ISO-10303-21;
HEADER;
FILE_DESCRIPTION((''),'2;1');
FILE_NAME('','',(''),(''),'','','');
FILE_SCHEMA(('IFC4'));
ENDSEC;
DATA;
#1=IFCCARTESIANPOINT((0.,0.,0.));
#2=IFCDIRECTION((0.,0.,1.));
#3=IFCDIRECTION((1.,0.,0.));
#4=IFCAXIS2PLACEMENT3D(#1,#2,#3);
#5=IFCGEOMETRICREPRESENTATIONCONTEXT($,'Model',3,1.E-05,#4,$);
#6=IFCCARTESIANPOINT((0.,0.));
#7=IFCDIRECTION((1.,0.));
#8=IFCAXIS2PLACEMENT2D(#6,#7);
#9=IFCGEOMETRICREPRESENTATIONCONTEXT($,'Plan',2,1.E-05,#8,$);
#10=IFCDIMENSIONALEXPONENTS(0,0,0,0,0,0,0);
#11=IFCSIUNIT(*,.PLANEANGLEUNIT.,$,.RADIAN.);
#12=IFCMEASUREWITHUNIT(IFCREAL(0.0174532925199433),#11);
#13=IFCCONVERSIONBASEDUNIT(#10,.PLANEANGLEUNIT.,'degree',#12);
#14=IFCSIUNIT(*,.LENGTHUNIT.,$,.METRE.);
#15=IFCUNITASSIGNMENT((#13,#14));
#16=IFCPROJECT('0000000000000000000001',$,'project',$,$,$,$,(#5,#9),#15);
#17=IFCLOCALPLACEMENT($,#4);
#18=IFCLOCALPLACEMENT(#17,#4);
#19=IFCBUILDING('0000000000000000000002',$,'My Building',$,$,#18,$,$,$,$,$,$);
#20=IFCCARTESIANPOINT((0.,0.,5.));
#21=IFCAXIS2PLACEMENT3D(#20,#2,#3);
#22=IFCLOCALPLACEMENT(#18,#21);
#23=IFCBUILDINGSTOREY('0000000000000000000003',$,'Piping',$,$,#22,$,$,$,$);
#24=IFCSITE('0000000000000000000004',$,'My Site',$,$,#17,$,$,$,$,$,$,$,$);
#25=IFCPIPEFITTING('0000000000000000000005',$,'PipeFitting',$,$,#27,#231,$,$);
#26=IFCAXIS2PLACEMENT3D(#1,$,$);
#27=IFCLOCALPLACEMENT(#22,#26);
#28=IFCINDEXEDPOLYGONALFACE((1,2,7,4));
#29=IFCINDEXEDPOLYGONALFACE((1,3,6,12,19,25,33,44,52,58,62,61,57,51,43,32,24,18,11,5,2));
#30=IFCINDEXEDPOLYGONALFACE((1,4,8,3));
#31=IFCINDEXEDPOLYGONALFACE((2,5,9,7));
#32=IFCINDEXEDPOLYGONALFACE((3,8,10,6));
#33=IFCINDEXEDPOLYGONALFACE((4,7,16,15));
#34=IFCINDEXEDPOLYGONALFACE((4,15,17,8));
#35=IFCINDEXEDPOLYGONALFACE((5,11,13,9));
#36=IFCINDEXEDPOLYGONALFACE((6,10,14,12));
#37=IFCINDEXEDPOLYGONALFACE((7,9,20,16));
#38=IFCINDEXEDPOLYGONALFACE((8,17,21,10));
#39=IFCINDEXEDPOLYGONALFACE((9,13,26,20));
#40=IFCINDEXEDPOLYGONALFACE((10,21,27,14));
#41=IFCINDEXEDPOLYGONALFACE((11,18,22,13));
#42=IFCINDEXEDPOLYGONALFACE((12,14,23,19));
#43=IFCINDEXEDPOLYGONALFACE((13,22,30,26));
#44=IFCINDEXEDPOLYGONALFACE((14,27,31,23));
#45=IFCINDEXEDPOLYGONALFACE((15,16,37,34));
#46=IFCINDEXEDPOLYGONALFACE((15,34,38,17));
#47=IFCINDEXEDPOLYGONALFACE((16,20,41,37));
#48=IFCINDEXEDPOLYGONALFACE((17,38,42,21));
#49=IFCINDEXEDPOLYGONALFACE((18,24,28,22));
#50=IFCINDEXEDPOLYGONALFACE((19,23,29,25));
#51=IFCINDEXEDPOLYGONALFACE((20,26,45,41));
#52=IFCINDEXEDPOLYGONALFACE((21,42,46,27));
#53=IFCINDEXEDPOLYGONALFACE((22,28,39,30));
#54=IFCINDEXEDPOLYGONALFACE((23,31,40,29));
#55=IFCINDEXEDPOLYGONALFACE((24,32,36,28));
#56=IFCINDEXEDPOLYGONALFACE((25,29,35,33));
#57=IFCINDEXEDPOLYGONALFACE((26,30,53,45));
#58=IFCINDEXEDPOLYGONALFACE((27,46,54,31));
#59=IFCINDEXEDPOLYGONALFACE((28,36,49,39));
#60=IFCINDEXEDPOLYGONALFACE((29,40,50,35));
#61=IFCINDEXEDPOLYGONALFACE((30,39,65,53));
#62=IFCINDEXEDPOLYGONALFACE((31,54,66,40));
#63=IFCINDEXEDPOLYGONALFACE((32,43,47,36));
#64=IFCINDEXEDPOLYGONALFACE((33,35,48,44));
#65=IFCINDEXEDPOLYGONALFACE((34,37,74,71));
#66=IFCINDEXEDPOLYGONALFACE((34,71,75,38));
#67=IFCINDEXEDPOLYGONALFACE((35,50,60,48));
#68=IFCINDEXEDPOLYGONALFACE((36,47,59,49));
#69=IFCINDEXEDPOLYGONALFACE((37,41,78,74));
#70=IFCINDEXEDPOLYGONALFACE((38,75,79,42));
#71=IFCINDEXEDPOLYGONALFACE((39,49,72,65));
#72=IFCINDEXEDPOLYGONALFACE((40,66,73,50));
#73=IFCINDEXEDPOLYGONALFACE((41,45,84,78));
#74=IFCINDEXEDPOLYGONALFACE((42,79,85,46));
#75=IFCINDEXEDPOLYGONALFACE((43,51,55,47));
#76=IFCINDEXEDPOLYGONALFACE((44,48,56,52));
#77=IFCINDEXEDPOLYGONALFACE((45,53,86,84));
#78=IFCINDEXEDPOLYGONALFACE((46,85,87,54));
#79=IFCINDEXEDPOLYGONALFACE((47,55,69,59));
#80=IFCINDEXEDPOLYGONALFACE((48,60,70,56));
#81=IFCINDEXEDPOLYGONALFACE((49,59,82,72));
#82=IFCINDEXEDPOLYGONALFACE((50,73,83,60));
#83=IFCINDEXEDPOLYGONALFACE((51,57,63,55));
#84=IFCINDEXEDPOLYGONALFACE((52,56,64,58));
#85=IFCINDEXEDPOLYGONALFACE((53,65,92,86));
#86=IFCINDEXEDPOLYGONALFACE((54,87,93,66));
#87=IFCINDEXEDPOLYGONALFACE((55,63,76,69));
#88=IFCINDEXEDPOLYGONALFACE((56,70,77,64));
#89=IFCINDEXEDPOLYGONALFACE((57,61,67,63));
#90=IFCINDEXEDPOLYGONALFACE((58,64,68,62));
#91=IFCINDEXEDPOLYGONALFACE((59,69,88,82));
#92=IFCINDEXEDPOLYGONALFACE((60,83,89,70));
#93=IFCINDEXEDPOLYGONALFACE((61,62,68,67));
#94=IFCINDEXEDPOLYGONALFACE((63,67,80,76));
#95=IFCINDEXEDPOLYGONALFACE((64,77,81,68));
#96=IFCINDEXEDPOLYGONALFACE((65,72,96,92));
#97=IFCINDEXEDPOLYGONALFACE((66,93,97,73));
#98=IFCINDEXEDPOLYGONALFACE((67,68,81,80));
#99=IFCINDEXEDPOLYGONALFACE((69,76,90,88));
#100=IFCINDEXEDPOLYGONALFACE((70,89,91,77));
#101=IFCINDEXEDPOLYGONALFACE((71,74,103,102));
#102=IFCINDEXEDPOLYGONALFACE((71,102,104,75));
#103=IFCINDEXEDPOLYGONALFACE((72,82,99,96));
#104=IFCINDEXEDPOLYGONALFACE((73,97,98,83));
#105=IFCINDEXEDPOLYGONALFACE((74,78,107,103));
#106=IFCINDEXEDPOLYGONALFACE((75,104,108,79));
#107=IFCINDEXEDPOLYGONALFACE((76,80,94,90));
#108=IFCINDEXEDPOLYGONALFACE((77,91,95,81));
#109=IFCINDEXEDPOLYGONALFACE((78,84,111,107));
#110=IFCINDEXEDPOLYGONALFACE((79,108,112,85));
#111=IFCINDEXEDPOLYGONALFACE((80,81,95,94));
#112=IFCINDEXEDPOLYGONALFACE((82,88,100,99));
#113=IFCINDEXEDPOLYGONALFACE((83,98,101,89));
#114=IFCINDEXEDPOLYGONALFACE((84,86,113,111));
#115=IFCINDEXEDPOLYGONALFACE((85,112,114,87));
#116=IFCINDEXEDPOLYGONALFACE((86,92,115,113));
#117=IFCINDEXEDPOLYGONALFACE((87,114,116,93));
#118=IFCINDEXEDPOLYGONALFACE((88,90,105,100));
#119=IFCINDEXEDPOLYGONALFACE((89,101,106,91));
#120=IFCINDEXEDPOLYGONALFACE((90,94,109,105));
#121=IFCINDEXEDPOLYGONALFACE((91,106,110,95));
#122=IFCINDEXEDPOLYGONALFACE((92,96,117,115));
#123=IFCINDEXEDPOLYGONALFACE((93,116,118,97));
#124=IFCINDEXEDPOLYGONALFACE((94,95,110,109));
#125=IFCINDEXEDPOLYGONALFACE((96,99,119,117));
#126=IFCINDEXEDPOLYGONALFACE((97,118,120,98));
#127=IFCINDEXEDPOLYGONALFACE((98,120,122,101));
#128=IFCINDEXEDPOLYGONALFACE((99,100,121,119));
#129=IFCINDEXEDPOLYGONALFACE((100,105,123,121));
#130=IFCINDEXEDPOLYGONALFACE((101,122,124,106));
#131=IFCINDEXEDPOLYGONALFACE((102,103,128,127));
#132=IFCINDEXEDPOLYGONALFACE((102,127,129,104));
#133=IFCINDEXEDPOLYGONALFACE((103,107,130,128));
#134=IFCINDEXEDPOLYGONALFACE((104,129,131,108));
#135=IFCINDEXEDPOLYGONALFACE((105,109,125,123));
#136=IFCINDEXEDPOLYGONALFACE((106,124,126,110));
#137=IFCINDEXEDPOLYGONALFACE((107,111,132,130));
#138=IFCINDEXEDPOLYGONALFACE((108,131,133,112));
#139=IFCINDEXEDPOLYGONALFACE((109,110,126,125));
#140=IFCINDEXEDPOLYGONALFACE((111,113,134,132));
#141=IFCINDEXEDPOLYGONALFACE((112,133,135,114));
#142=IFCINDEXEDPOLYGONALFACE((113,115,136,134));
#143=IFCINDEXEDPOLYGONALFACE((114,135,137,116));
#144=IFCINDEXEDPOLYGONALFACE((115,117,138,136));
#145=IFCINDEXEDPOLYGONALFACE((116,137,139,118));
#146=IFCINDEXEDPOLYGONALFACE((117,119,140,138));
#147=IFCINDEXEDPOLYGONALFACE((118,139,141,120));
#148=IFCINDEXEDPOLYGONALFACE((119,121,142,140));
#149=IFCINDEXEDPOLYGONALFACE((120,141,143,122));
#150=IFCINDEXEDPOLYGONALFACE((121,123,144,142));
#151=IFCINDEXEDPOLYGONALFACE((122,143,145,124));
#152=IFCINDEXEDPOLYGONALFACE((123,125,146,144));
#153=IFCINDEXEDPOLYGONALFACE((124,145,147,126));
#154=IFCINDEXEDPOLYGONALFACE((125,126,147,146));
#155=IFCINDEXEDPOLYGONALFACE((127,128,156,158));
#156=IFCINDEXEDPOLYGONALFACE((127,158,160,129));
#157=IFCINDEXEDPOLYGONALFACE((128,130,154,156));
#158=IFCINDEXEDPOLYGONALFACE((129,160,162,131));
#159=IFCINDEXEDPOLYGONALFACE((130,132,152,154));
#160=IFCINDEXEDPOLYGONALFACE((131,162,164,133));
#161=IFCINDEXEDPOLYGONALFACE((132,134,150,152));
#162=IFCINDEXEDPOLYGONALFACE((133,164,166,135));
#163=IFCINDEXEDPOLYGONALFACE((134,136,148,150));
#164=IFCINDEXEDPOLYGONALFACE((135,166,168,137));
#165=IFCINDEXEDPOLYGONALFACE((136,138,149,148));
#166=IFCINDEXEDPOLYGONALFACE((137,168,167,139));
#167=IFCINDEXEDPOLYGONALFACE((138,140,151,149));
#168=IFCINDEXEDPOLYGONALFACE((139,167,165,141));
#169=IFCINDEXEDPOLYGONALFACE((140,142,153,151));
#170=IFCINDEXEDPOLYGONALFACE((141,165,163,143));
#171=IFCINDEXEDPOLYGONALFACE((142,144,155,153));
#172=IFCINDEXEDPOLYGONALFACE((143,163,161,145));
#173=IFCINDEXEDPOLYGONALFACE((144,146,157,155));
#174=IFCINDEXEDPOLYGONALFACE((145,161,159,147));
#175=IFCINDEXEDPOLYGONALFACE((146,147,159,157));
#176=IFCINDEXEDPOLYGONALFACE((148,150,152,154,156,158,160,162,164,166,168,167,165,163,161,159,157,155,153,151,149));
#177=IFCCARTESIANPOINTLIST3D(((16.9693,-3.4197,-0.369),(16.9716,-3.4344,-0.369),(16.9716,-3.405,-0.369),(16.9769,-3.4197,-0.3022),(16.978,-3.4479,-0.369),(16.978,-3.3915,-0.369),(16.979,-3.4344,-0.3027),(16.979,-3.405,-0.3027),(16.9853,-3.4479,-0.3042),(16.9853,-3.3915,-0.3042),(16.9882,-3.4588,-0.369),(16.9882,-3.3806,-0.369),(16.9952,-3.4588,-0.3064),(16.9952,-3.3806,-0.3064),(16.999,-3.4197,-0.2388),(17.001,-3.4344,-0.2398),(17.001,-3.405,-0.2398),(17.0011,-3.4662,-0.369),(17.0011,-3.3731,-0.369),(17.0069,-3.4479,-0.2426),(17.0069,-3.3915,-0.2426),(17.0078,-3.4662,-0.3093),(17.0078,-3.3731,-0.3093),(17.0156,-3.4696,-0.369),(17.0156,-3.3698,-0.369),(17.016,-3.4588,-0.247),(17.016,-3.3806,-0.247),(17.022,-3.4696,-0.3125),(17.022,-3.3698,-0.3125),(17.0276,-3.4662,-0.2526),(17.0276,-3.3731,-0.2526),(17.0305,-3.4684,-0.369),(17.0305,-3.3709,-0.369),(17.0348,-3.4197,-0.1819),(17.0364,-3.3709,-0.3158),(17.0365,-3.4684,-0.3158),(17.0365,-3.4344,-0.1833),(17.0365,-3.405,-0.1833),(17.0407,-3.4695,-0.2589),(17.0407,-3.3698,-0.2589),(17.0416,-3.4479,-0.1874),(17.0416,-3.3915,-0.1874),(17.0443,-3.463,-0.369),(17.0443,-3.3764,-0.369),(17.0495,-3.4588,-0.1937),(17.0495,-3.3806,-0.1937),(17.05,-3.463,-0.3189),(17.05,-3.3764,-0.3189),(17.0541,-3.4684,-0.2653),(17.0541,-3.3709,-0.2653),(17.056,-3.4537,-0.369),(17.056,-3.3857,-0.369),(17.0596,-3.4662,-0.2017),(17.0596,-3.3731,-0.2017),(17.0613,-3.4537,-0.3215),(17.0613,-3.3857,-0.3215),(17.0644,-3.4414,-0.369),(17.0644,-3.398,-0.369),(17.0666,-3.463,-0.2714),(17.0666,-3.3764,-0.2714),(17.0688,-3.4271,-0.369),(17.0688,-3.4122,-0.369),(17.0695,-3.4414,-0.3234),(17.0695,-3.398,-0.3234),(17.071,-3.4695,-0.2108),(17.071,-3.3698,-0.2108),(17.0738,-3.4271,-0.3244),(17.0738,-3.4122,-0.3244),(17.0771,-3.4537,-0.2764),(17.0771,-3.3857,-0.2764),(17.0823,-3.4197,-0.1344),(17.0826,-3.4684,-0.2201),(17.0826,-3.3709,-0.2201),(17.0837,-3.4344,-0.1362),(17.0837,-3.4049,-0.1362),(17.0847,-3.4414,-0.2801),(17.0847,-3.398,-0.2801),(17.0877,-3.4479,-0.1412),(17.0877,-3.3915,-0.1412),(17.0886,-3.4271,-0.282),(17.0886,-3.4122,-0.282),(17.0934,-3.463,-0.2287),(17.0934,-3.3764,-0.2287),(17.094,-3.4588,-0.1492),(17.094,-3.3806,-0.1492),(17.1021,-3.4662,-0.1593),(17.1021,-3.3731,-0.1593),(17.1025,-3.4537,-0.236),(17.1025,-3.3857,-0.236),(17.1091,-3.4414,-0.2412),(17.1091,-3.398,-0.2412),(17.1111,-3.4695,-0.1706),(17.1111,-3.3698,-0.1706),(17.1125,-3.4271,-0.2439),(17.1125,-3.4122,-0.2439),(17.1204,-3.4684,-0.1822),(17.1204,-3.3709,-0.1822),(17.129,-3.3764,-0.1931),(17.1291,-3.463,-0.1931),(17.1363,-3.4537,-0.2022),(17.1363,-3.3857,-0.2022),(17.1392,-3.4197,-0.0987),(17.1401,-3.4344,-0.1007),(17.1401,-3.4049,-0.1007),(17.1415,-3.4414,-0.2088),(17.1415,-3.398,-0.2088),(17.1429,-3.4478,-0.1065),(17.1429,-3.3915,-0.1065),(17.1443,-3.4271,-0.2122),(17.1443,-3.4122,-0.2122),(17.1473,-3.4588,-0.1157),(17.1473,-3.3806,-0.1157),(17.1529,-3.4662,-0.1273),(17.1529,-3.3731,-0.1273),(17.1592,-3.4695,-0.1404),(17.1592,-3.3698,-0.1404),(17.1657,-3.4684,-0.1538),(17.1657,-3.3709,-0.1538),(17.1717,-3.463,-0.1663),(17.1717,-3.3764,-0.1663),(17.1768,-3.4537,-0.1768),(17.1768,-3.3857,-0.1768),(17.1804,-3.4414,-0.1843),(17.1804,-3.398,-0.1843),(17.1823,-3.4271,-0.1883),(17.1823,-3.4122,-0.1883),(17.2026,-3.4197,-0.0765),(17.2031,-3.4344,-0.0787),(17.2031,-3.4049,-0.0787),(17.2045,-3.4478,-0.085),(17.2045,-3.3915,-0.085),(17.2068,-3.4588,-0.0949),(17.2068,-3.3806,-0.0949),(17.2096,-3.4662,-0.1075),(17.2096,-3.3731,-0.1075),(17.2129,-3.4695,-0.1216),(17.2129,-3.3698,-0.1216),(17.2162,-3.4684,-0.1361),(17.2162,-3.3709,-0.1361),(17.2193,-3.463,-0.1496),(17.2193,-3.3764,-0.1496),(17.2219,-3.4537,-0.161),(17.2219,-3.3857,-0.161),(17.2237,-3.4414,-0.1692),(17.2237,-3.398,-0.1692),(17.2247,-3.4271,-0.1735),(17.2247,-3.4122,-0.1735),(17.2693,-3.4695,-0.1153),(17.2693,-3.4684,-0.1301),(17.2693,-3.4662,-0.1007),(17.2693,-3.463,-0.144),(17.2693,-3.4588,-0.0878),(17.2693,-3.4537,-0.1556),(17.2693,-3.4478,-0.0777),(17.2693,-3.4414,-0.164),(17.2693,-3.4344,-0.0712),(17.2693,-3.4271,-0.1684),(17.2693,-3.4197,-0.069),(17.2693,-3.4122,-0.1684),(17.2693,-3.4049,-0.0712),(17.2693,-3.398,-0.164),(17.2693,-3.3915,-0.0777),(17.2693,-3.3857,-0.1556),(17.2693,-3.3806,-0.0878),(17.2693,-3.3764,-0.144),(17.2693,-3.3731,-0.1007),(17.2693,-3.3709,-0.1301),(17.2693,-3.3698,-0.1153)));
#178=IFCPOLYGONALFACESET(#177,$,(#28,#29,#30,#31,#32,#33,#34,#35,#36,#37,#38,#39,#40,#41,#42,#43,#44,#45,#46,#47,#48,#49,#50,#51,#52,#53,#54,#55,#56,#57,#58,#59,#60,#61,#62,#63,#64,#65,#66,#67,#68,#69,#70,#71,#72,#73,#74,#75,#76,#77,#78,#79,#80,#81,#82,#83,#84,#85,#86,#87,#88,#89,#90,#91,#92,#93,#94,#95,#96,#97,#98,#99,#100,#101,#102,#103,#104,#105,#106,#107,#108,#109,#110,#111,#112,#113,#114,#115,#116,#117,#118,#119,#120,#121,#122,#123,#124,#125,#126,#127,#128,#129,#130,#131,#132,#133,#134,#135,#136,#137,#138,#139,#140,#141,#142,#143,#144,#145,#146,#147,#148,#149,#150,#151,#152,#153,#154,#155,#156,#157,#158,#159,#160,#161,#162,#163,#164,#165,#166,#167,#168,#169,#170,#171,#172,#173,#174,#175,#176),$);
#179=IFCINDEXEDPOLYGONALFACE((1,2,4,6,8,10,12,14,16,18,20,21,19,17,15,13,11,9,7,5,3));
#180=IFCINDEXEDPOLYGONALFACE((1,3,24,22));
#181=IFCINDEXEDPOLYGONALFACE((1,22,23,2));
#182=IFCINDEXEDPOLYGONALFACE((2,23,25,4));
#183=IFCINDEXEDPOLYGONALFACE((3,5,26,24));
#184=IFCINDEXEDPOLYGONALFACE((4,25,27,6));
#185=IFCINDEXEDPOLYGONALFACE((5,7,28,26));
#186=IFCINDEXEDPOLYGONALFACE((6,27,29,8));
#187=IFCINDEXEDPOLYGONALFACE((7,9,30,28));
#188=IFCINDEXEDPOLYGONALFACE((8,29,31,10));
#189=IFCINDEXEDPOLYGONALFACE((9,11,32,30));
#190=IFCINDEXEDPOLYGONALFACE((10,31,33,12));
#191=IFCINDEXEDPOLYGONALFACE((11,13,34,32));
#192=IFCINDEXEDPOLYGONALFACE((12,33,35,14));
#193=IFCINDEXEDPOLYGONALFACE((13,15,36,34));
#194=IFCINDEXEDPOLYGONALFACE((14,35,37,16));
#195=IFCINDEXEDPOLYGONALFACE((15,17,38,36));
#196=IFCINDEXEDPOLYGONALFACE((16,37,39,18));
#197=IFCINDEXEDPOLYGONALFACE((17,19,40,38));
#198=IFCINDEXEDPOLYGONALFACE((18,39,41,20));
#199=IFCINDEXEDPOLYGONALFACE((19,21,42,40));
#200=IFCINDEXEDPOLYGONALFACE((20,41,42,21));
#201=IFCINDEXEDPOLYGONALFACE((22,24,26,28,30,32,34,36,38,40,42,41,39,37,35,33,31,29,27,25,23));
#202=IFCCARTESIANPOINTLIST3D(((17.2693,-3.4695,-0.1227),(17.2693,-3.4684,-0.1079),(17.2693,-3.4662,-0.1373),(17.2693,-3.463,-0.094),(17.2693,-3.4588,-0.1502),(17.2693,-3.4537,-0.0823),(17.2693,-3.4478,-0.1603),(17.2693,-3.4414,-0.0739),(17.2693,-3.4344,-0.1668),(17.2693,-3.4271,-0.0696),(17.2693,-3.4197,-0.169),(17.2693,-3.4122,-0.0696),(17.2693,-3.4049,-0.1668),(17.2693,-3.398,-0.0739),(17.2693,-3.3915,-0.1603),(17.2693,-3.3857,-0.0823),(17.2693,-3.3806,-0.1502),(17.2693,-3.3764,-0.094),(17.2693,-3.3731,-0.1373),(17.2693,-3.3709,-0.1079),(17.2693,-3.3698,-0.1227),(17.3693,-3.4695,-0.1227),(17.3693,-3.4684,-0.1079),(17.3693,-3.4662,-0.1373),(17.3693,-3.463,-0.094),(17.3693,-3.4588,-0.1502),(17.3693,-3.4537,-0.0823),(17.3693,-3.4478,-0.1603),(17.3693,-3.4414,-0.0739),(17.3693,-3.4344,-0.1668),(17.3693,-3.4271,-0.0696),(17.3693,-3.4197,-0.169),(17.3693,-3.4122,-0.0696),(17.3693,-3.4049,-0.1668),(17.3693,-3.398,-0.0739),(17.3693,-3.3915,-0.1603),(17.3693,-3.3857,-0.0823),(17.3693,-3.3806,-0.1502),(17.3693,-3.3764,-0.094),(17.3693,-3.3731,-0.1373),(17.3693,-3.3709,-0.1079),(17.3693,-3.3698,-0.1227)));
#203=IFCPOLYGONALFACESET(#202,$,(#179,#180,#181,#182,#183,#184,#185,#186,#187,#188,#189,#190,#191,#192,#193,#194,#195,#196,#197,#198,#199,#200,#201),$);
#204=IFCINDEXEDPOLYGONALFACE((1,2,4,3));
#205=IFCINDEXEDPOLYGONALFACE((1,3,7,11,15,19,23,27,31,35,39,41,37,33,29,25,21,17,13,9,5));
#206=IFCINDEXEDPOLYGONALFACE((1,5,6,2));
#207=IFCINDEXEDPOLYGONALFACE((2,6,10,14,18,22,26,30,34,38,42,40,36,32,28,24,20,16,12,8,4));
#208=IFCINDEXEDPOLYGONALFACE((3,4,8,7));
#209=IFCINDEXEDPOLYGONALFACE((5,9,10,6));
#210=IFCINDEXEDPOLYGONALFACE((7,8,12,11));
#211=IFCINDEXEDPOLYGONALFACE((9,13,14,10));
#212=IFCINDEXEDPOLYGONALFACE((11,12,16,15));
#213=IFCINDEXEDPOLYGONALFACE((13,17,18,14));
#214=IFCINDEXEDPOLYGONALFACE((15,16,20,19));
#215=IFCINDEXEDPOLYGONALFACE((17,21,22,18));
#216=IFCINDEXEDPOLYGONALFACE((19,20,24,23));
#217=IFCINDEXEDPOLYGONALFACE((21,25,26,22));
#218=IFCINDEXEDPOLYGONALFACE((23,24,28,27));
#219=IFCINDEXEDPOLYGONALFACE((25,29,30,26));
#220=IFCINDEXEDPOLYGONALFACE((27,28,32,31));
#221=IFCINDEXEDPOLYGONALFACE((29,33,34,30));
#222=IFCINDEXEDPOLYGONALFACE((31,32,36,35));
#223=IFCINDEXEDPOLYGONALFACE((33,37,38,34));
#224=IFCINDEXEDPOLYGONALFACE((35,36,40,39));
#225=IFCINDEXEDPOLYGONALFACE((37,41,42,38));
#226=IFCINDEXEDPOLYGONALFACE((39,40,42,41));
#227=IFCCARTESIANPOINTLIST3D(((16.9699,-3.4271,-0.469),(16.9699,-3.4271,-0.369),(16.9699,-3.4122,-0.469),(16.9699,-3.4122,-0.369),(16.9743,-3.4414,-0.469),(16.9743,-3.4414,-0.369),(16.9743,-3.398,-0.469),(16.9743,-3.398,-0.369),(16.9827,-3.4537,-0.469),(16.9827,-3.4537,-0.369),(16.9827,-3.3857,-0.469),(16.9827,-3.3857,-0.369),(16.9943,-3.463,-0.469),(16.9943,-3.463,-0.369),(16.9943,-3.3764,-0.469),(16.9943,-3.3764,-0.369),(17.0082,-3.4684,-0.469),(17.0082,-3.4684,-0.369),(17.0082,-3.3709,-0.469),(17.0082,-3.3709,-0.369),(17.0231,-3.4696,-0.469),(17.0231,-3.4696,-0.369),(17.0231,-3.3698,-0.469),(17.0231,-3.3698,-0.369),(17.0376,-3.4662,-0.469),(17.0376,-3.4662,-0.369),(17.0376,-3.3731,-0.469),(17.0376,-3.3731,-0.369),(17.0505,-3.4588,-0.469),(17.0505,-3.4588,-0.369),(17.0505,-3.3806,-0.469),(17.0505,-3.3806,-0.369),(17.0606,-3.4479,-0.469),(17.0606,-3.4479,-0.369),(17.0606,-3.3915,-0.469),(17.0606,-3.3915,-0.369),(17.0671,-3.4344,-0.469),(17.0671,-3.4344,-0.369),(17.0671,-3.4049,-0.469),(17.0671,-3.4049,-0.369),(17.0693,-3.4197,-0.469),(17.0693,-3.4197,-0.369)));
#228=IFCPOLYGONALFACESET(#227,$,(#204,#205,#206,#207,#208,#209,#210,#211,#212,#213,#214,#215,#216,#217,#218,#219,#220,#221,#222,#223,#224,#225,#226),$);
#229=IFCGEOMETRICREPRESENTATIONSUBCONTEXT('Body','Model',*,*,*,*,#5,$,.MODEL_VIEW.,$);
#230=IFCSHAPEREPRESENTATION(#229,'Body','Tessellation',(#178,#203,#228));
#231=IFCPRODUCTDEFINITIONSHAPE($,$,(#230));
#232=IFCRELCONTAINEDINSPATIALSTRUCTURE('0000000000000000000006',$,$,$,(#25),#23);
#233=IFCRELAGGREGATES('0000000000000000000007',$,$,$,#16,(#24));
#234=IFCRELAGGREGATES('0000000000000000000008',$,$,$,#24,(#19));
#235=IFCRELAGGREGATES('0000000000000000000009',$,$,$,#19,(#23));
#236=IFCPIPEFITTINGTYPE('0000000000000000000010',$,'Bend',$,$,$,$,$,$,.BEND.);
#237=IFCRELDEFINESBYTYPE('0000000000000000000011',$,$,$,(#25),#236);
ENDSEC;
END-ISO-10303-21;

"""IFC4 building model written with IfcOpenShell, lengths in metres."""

from ifc_helpers import new_model, entity, si_unit, converted_unit, frame, origin_with_axes, origin_2d_with_axis, place, context, subcontext, project, spatial, circle, extrude, source, transform, mapped, type_object, type_shapes, element, save


model = new_model("IFC4")

# Units and contexts
model_context = context("Model", 3, precision=1e-05, world=origin_with_axes())
plan_context = context("Plan", 2, precision=1e-05, world=origin_2d_with_axis())
body_context = subcontext(model_context, "Body", "Model", "MODEL_VIEW")
ifc_project = project(units=[converted_unit("PLANEANGLEUNIT", "degree", entity("IfcReal", 0.0174532925199433), si_unit("PLANEANGLEUNIT", "RADIAN"), dimensions=[0, 0, 0, 0, 0, 0, 0]), si_unit("LENGTHUNIT", "METRE")], contexts=[model_context, plan_context])

# Site, building, storey
site_placement = place(None, origin_with_axes())
site = spatial("IfcSite", under=ifc_project, at=site_placement, Name="My Site")
building_placement = place(site_placement, origin_with_axes())
building = spatial("IfcBuilding", under=site, at=building_placement, Name="My Building")
storey_placement = place(building_placement, frame((0.0, 0.0, 5.0), z_axis=(0.0, 0.0, 1.0), x_axis=(1.0, 0.0, 0.0)))
storey = spatial("IfcBuildingStorey", under=building, at=storey_placement, Name="Piping")

# Pipe fitting
pipe_fitting_type_1 = type_object("IfcPipeFittingType", Name="Bend", PredefinedType="BEND")
shared_shape = source(origin_with_axes(), body_context, "Body", "SolidModel", [
    entity("IfcSweptDiskSolid", entity("IfcIndexedPolyCurve", entity("IfcCartesianPointList3D", [[0.0, 0.0, -0.1], [0.0732, 0.0, -0.2768], [0.25, 0.0, -0.35]]), [entity("IfcArcIndex", [1, 2, 3])]), 0.05),
    extrude(circle(Radius=0.05), origin_with_axes(), (0.0, 0.0, -1.0), 0.1),
    extrude(circle(Radius=0.05), frame((0.25, 0.0, -0.35), z_axis=(1.0, 0.0, 0.0), x_axis=(0.0, 0.0, 1.0)), (0.0, 0.0, 1.0), 0.1),
])
type_shapes(pipe_fitting_type_1, [shared_shape])
for number, where, z_axis, x_axis, name in (
    (1, (17.3693, -3.4197, -0.119), (1.0, 0.00006, 0.0), (0.0, 0.0, -1.0), "PipeFitting"),
):
    element("IfcPipeFitting", number, at=place(storey_placement, frame(where, z_axis=z_axis, x_axis=x_axis)), inside=storey, type_object=pipe_fitting_type_1, Name=name, context=body_context, shape_type="MappedRepresentation", body=[
        mapped(shared_shape, transform((0.0, 0.0, 0.0), x_axis=(1.0, 0.0, 0.0), y_axis=(0.0, 1.0, 0.0), z_axis=(0.0, 0.0, 1.0), scale=1.0)),
    ])

save(model, "model.ifc")
